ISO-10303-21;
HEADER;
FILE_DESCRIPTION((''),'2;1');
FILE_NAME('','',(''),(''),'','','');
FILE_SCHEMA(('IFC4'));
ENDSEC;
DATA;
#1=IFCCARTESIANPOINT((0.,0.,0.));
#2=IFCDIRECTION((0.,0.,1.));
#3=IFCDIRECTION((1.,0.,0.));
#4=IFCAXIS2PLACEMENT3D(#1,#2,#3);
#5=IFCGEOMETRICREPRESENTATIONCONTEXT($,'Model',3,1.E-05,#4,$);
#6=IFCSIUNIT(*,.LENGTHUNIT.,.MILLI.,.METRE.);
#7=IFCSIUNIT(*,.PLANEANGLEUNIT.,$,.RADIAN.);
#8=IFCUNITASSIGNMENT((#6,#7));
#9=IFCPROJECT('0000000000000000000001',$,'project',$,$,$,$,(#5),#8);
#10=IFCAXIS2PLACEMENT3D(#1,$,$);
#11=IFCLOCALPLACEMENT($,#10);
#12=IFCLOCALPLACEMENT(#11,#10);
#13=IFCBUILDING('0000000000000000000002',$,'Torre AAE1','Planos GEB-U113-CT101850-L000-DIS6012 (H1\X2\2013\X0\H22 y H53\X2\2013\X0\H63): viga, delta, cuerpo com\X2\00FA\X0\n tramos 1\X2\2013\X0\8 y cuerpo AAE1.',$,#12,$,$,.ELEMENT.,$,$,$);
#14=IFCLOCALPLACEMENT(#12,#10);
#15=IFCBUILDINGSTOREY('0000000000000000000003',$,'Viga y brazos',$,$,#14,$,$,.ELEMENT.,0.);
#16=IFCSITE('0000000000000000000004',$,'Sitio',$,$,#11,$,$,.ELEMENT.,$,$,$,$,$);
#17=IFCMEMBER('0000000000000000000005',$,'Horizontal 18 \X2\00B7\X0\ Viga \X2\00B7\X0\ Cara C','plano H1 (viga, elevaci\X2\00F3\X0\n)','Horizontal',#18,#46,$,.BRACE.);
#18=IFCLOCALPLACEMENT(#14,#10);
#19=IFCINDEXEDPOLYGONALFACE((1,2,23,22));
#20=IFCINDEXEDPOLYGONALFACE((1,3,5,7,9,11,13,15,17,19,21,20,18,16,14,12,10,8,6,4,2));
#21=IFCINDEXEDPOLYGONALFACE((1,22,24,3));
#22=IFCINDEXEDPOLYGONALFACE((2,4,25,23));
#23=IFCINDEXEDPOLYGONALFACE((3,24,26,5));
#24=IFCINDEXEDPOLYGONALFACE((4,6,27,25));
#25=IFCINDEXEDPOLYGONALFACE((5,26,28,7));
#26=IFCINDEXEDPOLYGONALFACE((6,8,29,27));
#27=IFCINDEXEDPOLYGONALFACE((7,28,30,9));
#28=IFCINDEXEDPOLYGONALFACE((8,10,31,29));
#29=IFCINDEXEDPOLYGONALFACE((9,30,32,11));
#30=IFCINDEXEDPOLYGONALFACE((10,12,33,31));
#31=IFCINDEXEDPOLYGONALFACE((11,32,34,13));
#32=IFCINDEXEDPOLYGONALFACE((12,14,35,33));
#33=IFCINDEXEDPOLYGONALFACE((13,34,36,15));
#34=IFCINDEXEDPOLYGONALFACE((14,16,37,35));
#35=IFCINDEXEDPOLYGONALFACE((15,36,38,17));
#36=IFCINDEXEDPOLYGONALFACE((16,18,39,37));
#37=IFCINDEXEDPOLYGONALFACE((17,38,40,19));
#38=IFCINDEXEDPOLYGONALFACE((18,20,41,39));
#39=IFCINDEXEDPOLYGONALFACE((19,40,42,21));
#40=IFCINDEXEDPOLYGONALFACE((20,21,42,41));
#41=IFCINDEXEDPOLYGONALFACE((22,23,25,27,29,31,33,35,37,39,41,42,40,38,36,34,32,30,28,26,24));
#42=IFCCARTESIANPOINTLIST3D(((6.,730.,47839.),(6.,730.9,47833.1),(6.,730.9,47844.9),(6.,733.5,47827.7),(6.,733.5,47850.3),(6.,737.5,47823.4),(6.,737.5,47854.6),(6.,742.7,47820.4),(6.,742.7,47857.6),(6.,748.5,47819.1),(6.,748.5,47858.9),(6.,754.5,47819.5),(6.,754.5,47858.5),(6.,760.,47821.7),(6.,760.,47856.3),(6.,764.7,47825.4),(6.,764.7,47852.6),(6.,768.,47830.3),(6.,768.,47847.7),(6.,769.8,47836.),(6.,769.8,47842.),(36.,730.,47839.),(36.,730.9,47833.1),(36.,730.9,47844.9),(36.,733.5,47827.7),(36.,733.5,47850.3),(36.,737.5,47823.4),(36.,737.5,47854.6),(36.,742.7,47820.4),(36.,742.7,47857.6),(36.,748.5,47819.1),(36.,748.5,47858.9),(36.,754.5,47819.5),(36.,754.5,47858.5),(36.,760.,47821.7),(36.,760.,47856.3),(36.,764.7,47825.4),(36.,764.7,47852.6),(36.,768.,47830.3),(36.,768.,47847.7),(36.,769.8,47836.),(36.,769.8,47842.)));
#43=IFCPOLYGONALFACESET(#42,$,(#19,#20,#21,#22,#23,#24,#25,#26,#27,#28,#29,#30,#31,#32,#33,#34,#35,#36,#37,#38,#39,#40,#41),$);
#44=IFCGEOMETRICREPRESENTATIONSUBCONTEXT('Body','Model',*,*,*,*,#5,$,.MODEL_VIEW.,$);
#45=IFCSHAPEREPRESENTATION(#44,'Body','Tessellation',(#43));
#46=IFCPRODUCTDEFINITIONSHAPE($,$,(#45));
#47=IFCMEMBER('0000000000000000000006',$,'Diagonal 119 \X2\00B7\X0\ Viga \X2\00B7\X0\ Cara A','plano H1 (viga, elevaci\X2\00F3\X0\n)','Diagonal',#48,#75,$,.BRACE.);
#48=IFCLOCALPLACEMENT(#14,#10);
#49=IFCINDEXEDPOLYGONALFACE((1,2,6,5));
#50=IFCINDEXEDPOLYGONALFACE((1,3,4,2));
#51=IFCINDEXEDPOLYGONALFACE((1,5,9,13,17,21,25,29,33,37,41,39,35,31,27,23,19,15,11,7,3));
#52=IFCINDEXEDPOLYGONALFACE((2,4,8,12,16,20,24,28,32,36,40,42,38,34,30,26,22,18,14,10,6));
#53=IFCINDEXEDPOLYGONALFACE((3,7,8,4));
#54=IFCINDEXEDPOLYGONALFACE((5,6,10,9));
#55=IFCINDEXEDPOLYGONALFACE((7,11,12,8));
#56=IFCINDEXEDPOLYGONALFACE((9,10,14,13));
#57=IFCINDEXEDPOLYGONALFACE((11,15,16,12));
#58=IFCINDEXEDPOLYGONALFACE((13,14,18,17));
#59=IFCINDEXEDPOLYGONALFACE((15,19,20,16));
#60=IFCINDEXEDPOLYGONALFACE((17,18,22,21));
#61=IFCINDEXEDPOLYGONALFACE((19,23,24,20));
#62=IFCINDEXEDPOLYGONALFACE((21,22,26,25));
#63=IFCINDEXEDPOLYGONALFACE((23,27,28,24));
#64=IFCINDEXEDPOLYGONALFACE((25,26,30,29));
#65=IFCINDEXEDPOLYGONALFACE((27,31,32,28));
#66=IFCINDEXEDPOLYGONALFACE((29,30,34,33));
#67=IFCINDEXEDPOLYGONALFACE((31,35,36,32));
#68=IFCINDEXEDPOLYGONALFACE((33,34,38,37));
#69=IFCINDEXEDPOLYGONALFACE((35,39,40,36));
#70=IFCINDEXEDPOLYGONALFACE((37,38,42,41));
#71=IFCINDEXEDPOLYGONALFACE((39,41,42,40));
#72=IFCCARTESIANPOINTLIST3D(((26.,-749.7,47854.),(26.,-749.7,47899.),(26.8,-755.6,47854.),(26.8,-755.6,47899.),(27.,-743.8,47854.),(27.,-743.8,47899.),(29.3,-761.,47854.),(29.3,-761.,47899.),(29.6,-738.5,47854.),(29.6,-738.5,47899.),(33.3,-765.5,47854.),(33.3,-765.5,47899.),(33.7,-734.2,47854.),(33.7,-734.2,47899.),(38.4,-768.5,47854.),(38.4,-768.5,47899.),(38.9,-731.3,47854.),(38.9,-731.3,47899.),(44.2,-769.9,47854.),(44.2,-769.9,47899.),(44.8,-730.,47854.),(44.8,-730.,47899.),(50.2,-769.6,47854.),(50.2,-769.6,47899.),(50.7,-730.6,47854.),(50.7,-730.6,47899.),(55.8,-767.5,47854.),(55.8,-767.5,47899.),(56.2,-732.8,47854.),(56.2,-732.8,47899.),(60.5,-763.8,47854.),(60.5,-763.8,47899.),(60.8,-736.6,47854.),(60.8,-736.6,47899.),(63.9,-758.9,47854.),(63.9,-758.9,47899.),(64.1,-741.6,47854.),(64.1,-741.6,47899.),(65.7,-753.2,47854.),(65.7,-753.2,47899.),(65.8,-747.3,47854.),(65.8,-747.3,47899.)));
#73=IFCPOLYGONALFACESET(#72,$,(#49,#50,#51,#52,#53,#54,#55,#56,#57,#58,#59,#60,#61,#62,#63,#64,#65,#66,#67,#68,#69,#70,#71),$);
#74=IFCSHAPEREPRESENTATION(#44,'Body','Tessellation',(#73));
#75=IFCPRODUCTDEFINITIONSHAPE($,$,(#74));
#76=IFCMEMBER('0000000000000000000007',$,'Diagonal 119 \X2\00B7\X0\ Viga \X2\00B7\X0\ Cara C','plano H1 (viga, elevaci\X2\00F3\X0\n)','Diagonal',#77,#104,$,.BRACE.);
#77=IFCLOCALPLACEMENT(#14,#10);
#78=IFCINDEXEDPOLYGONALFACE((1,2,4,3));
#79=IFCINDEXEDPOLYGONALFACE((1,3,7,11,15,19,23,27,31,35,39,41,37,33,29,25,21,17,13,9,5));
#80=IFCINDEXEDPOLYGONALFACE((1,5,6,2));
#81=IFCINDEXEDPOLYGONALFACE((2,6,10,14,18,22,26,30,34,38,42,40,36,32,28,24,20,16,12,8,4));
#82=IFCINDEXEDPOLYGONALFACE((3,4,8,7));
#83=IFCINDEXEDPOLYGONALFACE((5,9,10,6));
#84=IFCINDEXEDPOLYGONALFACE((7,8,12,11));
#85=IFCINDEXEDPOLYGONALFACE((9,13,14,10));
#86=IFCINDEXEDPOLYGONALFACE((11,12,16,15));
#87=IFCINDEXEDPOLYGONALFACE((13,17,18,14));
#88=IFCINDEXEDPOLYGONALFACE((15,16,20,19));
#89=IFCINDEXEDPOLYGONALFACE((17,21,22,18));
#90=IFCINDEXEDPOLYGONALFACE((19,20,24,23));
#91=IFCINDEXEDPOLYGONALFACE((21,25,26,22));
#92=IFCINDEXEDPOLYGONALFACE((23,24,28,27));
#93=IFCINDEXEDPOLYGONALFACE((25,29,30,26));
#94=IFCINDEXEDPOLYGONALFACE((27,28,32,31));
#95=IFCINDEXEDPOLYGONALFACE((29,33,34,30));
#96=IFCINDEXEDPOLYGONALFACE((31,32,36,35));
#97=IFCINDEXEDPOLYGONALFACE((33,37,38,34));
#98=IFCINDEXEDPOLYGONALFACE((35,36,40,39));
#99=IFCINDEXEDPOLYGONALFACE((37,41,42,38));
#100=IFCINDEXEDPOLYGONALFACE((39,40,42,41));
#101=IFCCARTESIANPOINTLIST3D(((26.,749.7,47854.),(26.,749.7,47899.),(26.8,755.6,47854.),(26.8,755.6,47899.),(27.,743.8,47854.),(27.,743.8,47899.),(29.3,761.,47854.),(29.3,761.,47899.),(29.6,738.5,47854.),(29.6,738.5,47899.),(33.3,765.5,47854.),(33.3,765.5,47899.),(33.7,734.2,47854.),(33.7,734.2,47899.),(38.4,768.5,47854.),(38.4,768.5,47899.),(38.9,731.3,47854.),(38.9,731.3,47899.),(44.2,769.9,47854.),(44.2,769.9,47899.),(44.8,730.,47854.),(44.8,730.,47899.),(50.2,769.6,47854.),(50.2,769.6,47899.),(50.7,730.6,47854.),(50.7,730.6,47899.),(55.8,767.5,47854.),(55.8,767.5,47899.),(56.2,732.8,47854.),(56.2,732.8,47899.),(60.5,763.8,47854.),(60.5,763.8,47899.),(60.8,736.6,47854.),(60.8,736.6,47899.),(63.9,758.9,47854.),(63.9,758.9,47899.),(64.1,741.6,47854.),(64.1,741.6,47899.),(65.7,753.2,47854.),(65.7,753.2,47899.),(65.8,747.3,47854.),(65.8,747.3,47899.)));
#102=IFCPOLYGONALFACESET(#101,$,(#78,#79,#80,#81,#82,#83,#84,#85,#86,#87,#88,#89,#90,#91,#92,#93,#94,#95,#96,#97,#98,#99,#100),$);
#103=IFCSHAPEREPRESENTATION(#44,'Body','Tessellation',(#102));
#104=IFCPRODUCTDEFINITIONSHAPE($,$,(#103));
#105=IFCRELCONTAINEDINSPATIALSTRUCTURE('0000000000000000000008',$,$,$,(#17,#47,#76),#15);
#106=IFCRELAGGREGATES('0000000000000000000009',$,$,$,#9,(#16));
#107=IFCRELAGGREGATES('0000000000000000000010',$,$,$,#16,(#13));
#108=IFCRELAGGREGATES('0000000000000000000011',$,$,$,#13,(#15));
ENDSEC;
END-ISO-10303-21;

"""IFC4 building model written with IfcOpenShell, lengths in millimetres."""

from ifc_helpers import new_model, si_unit, frame, origin, origin_with_axes, place, context, subcontext, project, spatial, circle, extrude, element, save


model = new_model("IFC4")

# Units and contexts
model_context = context("Model", 3, precision=1e-05, world=origin_with_axes())
body_context = subcontext(model_context, "Body", "Model", "MODEL_VIEW")
ifc_project = project(units=[si_unit("LENGTHUNIT", "METRE", prefix="MILLI"), si_unit("PLANEANGLEUNIT", "RADIAN")], contexts=[model_context])

# Site, building, storey
site_placement = place(None, origin())
site = spatial("IfcSite", under=ifc_project, at=site_placement, Name="Sitio", CompositionType="ELEMENT")
building_placement = place(site_placement, origin())
building = spatial("IfcBuilding", under=site, at=building_placement, Name="Torre AAE1", Description="Planos GEB-U113-CT101850-L000-DIS6012 (H1–H22 y H53–H63): viga, delta, cuerpo común tramos 1–8 y cuerpo AAE1.", CompositionType="ELEMENT")
storey_placement = place(building_placement, origin())
storey = spatial("IfcBuildingStorey", under=building, at=storey_placement, Name="Viga y brazos", CompositionType="ELEMENT", Elevation=0.0)

# Members
for number, where, z_axis, x_axis, name in (
    (1, (6.0, 750.0, 47839.0), (1.0, 0.0, 0.0), (0.0, -1.0, 0.0), "Horizontal 18 · Viga · Cara C"),
):
    element("IfcMember", number, at=place(storey_placement, frame(where, z_axis=z_axis, x_axis=x_axis)), inside=storey, Name=name, Description="plano H1 (viga, elevación)", ObjectType="Horizontal", PredefinedType="BRACE", context=body_context, shape_type="SweptSolid", body=[
        extrude(circle(Radius=20.0), None, (0.0, 0.0, 1.0), 30.0),
    ])
for number, where, z_axis, x_axis, name in (
    (2, (46.0, -750.0, 47899.0), (0.0, 0.0, -1.0), (-0.061218, 0.998124, 0.0), "Diagonal 119 · Viga · Cara A"),
    (3, (46.0, 750.0, 47899.0), (0.0, 0.0, -1.0), (-0.061218, -0.998124, 0.0), "Diagonal 119 · Viga · Cara C"),
):
    element("IfcMember", number, at=place(storey_placement, frame(where, z_axis=z_axis, x_axis=x_axis)), inside=storey, Name=name, Description="plano H1 (viga, elevación)", ObjectType="Diagonal", PredefinedType="BRACE", context=body_context, shape_type="SweptSolid", body=[
        extrude(circle(Radius=20.0), None, (0.0, 0.0, 1.0), 45.0),
    ])

save(model, "model.ifc")
